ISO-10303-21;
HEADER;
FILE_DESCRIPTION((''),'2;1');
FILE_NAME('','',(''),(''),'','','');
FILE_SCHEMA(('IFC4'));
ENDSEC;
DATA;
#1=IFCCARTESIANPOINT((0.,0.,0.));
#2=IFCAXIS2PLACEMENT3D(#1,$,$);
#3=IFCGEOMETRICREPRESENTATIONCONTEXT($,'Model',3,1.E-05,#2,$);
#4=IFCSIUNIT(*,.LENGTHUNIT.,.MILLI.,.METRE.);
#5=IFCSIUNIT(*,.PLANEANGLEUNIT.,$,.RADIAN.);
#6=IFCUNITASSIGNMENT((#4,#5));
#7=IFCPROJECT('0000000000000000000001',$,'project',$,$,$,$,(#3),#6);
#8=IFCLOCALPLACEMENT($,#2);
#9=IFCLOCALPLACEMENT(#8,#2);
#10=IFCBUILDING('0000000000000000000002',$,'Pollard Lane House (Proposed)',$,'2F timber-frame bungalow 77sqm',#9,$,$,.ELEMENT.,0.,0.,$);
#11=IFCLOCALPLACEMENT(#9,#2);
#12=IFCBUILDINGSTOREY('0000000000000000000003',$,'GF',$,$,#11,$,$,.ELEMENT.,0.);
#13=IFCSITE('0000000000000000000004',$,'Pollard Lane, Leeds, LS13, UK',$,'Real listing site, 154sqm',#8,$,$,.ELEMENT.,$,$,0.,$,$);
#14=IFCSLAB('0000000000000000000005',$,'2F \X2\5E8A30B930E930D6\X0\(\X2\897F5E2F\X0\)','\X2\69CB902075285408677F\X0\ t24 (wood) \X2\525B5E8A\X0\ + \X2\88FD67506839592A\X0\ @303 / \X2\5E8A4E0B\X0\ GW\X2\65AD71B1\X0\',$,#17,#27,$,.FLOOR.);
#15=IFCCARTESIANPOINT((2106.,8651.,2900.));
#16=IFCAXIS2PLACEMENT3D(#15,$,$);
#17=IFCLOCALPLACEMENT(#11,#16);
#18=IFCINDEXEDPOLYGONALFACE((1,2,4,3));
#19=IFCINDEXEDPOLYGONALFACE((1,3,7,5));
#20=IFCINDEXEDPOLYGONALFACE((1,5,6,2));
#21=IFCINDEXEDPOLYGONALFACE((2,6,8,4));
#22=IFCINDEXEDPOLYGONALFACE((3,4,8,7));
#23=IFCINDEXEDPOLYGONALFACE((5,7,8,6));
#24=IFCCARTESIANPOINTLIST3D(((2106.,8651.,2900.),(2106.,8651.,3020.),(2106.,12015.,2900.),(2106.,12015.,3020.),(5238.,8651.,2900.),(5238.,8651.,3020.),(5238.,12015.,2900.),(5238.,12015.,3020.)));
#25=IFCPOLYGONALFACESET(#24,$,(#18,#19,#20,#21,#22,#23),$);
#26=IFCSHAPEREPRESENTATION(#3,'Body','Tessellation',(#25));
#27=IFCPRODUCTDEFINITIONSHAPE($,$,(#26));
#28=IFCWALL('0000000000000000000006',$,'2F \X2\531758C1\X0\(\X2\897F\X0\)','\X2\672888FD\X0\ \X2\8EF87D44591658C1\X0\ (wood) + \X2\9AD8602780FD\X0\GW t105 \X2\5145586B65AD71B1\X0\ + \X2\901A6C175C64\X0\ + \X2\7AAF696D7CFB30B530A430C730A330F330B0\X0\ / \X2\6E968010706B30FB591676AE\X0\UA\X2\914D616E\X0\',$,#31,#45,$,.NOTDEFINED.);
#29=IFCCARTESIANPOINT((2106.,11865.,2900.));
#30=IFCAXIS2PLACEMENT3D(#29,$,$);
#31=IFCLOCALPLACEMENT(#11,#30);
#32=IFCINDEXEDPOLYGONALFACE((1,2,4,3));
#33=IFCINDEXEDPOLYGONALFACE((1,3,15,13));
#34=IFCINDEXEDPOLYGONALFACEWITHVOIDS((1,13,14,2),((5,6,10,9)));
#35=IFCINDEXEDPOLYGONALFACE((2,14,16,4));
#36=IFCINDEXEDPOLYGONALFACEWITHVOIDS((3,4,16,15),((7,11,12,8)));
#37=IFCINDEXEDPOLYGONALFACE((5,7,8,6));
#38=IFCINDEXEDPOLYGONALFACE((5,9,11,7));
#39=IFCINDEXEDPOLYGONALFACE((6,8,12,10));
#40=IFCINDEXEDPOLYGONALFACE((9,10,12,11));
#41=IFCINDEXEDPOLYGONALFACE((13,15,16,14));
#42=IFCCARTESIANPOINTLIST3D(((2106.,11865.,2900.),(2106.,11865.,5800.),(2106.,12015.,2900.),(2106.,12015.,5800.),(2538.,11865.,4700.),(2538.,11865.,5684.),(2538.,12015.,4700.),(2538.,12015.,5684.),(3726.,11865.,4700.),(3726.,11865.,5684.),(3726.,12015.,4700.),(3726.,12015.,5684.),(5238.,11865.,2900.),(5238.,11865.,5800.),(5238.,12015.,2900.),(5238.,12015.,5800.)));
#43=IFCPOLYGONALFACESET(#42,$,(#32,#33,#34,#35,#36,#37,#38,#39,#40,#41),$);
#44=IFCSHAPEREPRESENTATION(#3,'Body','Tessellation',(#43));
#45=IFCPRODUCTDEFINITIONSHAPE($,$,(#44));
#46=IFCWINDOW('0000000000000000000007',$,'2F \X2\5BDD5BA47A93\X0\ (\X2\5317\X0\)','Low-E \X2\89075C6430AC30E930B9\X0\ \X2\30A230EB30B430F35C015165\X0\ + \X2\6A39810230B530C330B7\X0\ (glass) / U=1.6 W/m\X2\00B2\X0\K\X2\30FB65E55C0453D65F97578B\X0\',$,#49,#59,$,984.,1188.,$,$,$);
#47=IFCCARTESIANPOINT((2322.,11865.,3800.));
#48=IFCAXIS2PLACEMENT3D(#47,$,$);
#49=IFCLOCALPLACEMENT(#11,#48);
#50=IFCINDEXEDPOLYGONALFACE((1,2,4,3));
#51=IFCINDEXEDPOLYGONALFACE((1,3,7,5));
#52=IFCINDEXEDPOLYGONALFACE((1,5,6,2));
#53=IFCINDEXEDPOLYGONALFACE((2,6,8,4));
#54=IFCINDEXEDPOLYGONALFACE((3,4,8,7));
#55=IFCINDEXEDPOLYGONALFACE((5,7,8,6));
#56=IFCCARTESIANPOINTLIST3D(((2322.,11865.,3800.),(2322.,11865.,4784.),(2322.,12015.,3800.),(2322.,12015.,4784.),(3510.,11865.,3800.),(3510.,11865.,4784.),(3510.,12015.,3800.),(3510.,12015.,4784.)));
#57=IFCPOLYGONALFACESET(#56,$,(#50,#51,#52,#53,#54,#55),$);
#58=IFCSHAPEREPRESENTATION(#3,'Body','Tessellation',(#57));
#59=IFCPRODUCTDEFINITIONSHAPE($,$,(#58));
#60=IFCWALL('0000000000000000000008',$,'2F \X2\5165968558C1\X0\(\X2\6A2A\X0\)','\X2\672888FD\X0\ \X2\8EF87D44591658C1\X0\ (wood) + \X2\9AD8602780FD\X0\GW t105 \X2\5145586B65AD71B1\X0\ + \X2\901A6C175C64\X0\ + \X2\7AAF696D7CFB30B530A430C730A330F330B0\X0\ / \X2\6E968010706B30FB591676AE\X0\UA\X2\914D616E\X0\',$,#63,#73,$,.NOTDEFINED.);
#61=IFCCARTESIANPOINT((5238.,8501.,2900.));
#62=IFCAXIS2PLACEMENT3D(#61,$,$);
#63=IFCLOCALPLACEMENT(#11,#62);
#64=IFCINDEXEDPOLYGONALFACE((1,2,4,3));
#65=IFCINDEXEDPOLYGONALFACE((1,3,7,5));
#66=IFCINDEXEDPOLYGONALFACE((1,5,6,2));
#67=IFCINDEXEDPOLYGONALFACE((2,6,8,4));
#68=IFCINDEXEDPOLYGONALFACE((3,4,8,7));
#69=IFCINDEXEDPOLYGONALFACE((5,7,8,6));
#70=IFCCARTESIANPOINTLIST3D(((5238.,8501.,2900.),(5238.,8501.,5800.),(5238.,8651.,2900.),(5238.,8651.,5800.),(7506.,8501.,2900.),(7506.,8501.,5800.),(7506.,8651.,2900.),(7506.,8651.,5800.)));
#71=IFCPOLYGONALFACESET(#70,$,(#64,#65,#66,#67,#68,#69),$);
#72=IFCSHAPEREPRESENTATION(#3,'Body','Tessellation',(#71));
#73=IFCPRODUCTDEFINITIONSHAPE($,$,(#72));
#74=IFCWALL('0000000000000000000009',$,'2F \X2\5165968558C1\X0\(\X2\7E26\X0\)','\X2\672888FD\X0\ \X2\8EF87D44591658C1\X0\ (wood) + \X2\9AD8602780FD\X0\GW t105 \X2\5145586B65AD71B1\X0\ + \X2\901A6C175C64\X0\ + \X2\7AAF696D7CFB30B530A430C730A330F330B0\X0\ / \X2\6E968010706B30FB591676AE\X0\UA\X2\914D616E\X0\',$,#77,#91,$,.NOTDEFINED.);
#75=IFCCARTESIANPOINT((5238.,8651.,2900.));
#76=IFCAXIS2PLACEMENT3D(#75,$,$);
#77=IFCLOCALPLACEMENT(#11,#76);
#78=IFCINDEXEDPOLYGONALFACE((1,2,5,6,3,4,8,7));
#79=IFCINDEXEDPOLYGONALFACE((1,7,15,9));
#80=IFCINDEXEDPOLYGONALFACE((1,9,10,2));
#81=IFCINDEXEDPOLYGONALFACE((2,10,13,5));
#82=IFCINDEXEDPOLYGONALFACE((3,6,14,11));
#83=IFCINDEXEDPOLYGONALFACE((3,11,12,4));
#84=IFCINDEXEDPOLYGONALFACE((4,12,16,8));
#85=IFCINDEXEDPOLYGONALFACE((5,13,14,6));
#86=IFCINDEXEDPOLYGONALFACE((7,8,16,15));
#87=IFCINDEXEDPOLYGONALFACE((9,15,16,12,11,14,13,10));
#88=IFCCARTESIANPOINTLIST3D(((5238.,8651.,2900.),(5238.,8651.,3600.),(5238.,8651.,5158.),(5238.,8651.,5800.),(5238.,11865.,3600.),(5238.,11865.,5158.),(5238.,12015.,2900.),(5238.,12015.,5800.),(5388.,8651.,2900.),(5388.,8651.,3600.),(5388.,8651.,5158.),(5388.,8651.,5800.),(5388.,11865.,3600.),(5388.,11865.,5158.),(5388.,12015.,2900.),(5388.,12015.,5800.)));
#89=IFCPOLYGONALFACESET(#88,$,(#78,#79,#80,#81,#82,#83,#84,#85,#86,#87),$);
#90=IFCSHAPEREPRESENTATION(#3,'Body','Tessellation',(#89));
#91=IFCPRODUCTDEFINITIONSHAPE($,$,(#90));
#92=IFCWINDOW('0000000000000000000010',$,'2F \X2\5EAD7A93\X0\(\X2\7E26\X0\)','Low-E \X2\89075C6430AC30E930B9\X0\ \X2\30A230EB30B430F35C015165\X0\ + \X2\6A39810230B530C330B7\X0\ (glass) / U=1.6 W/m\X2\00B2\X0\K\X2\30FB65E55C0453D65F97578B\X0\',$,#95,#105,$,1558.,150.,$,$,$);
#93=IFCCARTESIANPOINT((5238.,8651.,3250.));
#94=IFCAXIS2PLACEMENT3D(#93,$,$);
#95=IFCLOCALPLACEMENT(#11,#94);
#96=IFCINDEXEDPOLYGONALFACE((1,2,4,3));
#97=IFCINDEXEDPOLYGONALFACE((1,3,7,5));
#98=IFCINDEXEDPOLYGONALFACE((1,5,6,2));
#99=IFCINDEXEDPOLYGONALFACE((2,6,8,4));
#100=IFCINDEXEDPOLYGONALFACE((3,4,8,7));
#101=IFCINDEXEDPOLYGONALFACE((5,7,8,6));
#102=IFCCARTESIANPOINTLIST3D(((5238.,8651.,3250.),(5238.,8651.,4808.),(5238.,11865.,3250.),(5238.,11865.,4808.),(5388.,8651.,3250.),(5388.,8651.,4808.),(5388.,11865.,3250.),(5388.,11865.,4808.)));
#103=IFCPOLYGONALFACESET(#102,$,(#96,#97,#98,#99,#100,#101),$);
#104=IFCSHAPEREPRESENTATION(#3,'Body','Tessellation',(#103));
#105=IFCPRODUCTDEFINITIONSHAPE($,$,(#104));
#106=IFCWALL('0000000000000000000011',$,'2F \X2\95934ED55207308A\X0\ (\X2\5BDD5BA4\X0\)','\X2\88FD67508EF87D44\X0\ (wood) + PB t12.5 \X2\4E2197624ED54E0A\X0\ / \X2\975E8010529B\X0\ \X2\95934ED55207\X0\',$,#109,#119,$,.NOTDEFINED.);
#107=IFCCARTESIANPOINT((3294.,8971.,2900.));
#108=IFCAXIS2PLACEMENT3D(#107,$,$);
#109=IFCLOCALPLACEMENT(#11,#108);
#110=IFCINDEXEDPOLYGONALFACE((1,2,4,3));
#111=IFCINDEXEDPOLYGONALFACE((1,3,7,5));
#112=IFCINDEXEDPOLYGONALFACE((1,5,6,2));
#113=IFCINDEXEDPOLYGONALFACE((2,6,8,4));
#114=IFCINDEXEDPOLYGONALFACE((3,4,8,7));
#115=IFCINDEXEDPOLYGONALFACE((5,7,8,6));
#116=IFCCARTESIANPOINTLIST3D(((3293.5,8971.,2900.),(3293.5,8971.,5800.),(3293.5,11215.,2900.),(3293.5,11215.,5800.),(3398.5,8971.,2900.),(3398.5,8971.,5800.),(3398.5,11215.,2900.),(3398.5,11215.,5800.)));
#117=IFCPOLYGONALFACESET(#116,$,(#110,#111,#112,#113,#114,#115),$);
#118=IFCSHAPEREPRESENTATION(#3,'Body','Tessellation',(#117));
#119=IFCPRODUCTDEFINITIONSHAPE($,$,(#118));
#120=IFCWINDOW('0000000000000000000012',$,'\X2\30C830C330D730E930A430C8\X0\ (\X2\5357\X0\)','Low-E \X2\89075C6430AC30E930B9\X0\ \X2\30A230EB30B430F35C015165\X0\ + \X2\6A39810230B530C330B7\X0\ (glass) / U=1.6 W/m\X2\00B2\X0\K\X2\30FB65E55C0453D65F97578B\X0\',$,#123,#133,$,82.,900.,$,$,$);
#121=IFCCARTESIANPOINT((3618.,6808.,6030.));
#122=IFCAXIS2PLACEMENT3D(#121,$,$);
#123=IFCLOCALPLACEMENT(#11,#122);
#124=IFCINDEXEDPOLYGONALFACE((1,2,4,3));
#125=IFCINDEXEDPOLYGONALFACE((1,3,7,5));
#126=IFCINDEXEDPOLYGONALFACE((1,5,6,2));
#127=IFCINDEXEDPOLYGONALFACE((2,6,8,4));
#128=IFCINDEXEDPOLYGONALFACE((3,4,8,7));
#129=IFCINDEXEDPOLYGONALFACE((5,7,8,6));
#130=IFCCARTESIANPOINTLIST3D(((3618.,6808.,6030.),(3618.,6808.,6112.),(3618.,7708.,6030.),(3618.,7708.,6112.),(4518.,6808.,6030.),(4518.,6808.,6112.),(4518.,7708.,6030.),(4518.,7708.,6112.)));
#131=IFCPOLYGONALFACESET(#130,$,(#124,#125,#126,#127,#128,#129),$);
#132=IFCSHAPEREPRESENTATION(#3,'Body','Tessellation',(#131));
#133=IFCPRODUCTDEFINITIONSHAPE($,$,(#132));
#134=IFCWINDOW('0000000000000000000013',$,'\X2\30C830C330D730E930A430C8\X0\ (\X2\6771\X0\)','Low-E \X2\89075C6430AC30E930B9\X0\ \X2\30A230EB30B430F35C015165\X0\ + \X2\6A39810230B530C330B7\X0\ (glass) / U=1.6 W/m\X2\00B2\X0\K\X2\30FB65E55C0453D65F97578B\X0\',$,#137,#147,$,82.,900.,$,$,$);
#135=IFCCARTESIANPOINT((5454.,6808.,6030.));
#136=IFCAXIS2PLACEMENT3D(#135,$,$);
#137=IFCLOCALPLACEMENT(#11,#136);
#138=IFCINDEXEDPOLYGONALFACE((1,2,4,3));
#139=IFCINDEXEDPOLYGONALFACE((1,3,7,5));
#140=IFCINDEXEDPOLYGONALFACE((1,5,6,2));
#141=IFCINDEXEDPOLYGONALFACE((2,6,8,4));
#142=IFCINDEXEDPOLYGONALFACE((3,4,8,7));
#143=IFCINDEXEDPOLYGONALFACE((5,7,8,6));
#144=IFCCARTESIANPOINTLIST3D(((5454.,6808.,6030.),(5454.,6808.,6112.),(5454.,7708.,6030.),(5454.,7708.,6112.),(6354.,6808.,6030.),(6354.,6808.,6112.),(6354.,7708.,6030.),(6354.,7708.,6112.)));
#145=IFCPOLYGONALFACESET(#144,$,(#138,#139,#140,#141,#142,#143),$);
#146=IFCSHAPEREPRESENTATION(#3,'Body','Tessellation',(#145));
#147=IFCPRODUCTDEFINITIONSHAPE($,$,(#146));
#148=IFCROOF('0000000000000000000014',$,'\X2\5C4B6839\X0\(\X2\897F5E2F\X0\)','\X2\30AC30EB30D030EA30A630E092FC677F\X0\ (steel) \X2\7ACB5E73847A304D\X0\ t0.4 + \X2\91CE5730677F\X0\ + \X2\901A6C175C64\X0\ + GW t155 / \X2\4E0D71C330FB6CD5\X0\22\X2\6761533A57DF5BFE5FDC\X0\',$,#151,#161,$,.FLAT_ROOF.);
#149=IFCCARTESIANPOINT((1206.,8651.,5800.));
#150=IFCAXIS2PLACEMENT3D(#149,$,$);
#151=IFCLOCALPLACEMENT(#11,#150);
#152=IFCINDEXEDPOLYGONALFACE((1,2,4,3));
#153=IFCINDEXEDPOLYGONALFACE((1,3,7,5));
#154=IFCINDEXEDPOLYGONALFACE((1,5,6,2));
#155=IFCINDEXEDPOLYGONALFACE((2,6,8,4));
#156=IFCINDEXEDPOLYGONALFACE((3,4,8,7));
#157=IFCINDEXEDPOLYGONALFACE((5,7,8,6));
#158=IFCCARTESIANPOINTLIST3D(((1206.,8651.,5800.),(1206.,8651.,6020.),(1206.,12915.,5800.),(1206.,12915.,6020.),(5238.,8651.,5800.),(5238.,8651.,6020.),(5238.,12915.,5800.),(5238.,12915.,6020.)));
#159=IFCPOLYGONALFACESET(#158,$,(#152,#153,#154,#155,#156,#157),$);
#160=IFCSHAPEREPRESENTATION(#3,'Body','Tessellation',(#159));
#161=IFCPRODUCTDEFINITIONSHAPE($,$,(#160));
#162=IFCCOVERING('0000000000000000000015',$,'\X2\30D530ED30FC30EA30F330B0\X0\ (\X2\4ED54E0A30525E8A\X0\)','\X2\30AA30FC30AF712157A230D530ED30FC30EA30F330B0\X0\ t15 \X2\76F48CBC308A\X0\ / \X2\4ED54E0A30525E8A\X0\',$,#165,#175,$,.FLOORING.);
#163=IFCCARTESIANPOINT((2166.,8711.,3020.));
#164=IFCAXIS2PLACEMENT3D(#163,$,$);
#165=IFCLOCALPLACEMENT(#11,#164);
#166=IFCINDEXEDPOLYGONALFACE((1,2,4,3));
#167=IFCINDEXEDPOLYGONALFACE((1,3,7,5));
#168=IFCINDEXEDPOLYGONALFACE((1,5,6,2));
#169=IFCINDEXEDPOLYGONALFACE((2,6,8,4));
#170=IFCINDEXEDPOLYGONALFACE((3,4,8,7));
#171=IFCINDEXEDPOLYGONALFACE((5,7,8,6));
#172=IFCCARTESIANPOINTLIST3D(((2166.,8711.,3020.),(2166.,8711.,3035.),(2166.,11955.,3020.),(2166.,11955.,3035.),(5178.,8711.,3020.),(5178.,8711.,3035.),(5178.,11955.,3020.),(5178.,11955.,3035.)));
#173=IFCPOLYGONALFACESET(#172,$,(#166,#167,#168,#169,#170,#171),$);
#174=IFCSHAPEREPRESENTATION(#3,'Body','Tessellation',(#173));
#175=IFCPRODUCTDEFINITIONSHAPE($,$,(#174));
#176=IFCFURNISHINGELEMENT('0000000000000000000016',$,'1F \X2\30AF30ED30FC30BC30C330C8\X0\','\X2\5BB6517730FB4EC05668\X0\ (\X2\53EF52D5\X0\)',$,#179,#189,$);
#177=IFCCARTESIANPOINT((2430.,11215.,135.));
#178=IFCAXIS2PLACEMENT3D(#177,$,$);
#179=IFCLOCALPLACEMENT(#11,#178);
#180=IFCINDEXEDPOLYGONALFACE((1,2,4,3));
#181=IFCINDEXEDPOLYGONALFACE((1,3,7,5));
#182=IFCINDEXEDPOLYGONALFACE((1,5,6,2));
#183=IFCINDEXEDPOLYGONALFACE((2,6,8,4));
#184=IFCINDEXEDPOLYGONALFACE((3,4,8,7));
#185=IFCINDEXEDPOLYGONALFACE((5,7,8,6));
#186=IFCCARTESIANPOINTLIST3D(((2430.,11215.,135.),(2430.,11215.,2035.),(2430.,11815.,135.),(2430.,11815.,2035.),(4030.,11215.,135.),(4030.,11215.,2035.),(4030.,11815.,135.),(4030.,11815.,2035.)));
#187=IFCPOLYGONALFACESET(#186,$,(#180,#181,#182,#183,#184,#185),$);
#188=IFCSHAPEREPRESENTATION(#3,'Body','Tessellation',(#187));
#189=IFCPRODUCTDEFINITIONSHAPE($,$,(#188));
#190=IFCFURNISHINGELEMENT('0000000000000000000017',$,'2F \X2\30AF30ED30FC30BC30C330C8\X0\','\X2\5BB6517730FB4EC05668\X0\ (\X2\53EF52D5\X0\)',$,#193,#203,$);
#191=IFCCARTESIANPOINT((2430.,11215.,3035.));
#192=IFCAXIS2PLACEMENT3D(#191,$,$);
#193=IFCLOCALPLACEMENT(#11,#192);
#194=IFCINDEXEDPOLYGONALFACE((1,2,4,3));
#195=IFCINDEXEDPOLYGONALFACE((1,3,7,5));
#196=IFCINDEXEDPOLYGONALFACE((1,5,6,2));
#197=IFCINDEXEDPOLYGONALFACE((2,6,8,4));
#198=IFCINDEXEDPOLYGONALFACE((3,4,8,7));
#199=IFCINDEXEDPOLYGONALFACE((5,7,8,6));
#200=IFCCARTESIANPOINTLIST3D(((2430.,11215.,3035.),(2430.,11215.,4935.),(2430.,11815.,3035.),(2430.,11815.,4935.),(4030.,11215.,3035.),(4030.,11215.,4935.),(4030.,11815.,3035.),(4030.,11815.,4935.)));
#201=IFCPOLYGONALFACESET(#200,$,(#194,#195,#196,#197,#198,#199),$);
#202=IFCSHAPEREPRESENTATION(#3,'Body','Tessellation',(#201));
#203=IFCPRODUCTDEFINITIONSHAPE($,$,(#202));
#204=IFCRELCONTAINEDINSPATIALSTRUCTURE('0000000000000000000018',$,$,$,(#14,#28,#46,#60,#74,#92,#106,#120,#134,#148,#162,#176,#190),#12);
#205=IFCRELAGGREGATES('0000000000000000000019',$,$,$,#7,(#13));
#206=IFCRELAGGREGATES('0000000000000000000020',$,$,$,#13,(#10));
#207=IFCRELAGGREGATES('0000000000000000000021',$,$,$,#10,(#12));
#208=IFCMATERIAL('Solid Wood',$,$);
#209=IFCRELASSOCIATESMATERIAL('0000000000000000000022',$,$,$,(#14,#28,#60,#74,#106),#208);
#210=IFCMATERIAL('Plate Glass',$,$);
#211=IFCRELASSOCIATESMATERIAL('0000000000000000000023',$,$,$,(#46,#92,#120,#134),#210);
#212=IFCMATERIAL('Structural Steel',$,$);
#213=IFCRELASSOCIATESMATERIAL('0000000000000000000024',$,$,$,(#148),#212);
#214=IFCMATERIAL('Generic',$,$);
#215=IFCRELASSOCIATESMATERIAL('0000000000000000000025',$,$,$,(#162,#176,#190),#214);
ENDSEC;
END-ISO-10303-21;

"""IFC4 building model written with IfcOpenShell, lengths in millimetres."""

from ifc_helpers import new_model, si_unit, frame, frame_2d, origin, place, context, project, spatial, rectangle, extrude, material, element, fill, save


model = new_model("IFC4")

# Units and contexts
model_context = context("Model", 3, precision=1e-05, world=origin())
ifc_project = project(units=[si_unit("LENGTHUNIT", "METRE", prefix="MILLI"), si_unit("PLANEANGLEUNIT", "RADIAN")], contexts=[model_context])

# Site, building, storey
site_placement = place(None, origin())
site = spatial("IfcSite", under=ifc_project, at=site_placement, Name="Pollard Lane, Leeds, LS13, UK", ObjectType="Real listing site, 154sqm", CompositionType="ELEMENT", RefElevation=0.0)
building_placement = place(site_placement, origin())
building = spatial("IfcBuilding", under=site, at=building_placement, Name="Pollard Lane House (Proposed)", ObjectType="2F timber-frame bungalow 77sqm", CompositionType="ELEMENT", ElevationOfRefHeight=0.0, ElevationOfTerrain=0.0)
storey_placement = place(building_placement, origin())
storey = spatial("IfcBuildingStorey", under=building, at=storey_placement, Name="GF", CompositionType="ELEMENT", Elevation=0.0)

# Slab
ifc_material_1 = material(Name="Solid Wood")
slab_placement = place(storey_placement, frame((2106.0, 8651.0, 2900.0)))
element("IfcSlab", 1, at=slab_placement, inside=storey, material=ifc_material_1, Name="2F 床スラブ(西帯)", Description="構造用合板 t24 (wood) 剛床 + 製材根太 @303 / 床下 GW断熱", PredefinedType="FLOOR", context=model_context, shape_type="SweptSolid", body=[
    extrude(rectangle(XDim=3132.0, YDim=3364.0, at=frame_2d((1566.0, 1682.0))), frame((2106.0, 8651.0, 2900.0)), (0.0, 0.0, 1.0), 120.0),
])

# Wall, opening, window
wall_1_placement = place(storey_placement, frame((2106.0, 11865.0, 2900.0)))
wall_1 = element("IfcWall", 2, at=wall_1_placement, inside=storey, material=ifc_material_1, Name="2F 北壁(西)", Description="木製 軸組外壁 (wood) + 高性能GW t105 充填断熱 + 通気層 + 窯業系サイディング / 準耐火・外皮UA配慮", PredefinedType="NOTDEFINED", context=model_context, shape_type="SweptSolid", body=[
    extrude(rectangle(XDim=3132.0, YDim=150.0, at=frame_2d((1566.0, 75.0))), frame((2106.0, 11865.0, 2900.0)), (0.0, 0.0, 1.0), 2900.0),
])
opening_1_placement = place(storey_placement, frame((2322.0, 11865.0, 3800.0)))
opening_1 = element("IfcOpeningElement", 3, at=opening_1_placement, cuts=wall_1, PredefinedType="NOTDEFINED", context=model_context, shape_type="SweptSolid", body=[
    extrude(rectangle(XDim=1188.0, YDim=150.0, at=frame_2d((594.0, 75.0))), frame((2322.0, 11865.0, 3800.0)), (0.0, 0.0, 1.0), 984.0),
])
ifc_material_2 = material(Name="Plate Glass")
window_1_placement = place(storey_placement, frame((2322.0, 11865.0, 3800.0)))
window_1 = element("IfcWindow", 4, at=window_1_placement, inside=storey, material=ifc_material_2, Name="2F 寝室窓 (北)", Description="Low-E 複層ガラス アルゴン封入 + 樹脂サッシ (glass) / U=1.6 W/m²K・日射取得型", OverallHeight=984.0, OverallWidth=1188.0, context=model_context, shape_type="SweptSolid", body=[
    extrude(rectangle(XDim=1188.0, YDim=150.0, at=frame_2d((594.0, 75.0))), frame((2322.0, 11865.0, 3800.0)), (0.0, 0.0, 1.0), 984.0),
])
fill(opening_1, window_1)

# Wall
wall_2_placement = place(storey_placement, frame((5238.0, 8501.0, 2900.0)))
element("IfcWall", 5, at=wall_2_placement, inside=storey, material=ifc_material_1, Name="2F 入隅壁(横)", Description="木製 軸組外壁 (wood) + 高性能GW t105 充填断熱 + 通気層 + 窯業系サイディング / 準耐火・外皮UA配慮", PredefinedType="NOTDEFINED", context=model_context, shape_type="SweptSolid", body=[
    extrude(rectangle(XDim=2268.0, YDim=150.0, at=frame_2d((1134.0, 75.0))), frame((5238.0, 8501.0, 2900.0)), (0.0, 0.0, 1.0), 2900.0),
])

# Wall, opening, window
wall_3_placement = place(storey_placement, frame((5238.0, 8651.0, 2900.0)))
wall_3 = element("IfcWall", 6, at=wall_3_placement, inside=storey, material=ifc_material_1, Name="2F 入隅壁(縦)", Description="木製 軸組外壁 (wood) + 高性能GW t105 充填断熱 + 通気層 + 窯業系サイディング / 準耐火・外皮UA配慮", PredefinedType="NOTDEFINED", context=model_context, shape_type="SweptSolid", body=[
    extrude(rectangle(XDim=150.0, YDim=3364.0, at=frame_2d((75.0, 1682.0))), frame((5238.0, 8651.0, 2900.0)), (0.0, 0.0, 1.0), 2900.0),
])
opening_2_placement = place(storey_placement, frame((5238.0, 8651.0, 3250.0)))
opening_2 = element("IfcOpeningElement", 7, at=opening_2_placement, cuts=wall_3, PredefinedType="NOTDEFINED", context=model_context, shape_type="SweptSolid", body=[
    extrude(rectangle(XDim=150.0, YDim=3214.0, at=frame_2d((75.0, 1607.0))), frame((5238.0, 8651.0, 3250.0)), (0.0, 0.0, 1.0), 1558.0),
])
window_2_placement = place(storey_placement, frame((5238.0, 8651.0, 3250.0)))
window_2 = element("IfcWindow", 8, at=window_2_placement, inside=storey, material=ifc_material_2, Name="2F 庭窓(縦)", Description="Low-E 複層ガラス アルゴン封入 + 樹脂サッシ (glass) / U=1.6 W/m²K・日射取得型", OverallHeight=1558.0, OverallWidth=150.0, context=model_context, shape_type="SweptSolid", body=[
    extrude(rectangle(XDim=150.0, YDim=3214.0, at=frame_2d((75.0, 1607.0))), frame((5238.0, 8651.0, 3250.0)), (0.0, 0.0, 1.0), 1558.0),
])
fill(opening_2, window_2)

# Wall
wall_4_placement = place(storey_placement, frame((3294.0, 8971.0, 2900.0)))
element("IfcWall", 9, at=wall_4_placement, inside=storey, material=ifc_material_1, Name="2F 間仕切り (寝室)", Description="製材軸組 (wood) + PB t12.5 両面仕上 / 非耐力 間仕切", PredefinedType="NOTDEFINED", context=model_context, shape_type="SweptSolid", body=[
    extrude(rectangle(XDim=105.0, YDim=2244.0, at=frame_2d((52.0, 1122.0))), frame((3294.0, 8971.0, 2900.0)), (0.0, 0.0, 1.0), 2900.0),
])

# Windows
window_3_placement = place(storey_placement, frame((3618.0, 6808.0, 6030.0)))
element("IfcWindow", 10, at=window_3_placement, inside=storey, material=ifc_material_2, Name="トップライト (南)", Description="Low-E 複層ガラス アルゴン封入 + 樹脂サッシ (glass) / U=1.6 W/m²K・日射取得型", OverallHeight=82.0, OverallWidth=900.0, context=model_context, shape_type="SweptSolid", body=[
    extrude(rectangle(XDim=900.0, YDim=900.0, at=frame_2d((450.0, 450.0))), frame((3618.0, 6808.0, 6030.0)), (0.0, 0.0, 1.0), 82.0),
])
window_4_placement = place(storey_placement, frame((5454.0, 6808.0, 6030.0)))
element("IfcWindow", 11, at=window_4_placement, inside=storey, material=ifc_material_2, Name="トップライト (東)", Description="Low-E 複層ガラス アルゴン封入 + 樹脂サッシ (glass) / U=1.6 W/m²K・日射取得型", OverallHeight=82.0, OverallWidth=900.0, context=model_context, shape_type="SweptSolid", body=[
    extrude(rectangle(XDim=900.0, YDim=900.0, at=frame_2d((450.0, 450.0))), frame((5454.0, 6808.0, 6030.0)), (0.0, 0.0, 1.0), 82.0),
])

# Roof
ifc_material_3 = material(Name="Structural Steel")
for number, where, name in (
    (12, (1206.0, 8651.0, 5800.0), "屋根(西帯)"),
):
    element("IfcRoof", number, at=place(storey_placement, frame(where)), inside=storey, material=ifc_material_3, Name=name, Description="ガルバリウム鋼板 (steel) 立平葺き t0.4 + 野地板 + 通気層 + GW t155 / 不燃・法22条区域対応", PredefinedType="FLAT_ROOF", context=model_context, shape_type="SweptSolid", body=[
        extrude(rectangle(XDim=4032.0, YDim=4264.0, at=frame_2d((2016.0, 2132.0))), frame((1206.0, 8651.0, 5800.0)), (0.0, 0.0, 1.0), 220.0),
    ])

# Covering
ifc_material_4 = material(Name="Generic")
covering_placement = place(storey_placement, frame((2166.0, 8711.0, 3020.0)))
element("IfcCovering", 13, at=covering_placement, inside=storey, material=ifc_material_4, Name="フローリング (仕上げ床)", Description="オーク無垢フローリング t15 直貼り / 仕上げ床", PredefinedType="FLOORING", context=model_context, shape_type="SweptSolid", body=[
    extrude(rectangle(XDim=3012.0, YDim=3244.0, at=frame_2d((1506.0, 1622.0))), frame((2166.0, 8711.0, 3020.0)), (0.0, 0.0, 1.0), 15.0),
])

# Furnishing elements
furnishing_1_placement = place(storey_placement, frame((2430.0, 11215.0, 135.0)))
element("IfcFurnishingElement", 14, at=furnishing_1_placement, inside=storey, material=ifc_material_4, Name="1F クローゼット", Description="家具・什器 (可動)", context=model_context, shape_type="SweptSolid", body=[
    extrude(rectangle(XDim=1600.0, YDim=600.0, at=frame_2d((800.0, 300.0))), frame((2430.0, 11215.0, 135.0)), (0.0, 0.0, 1.0), 1900.0),
])
furnishing_2_placement = place(storey_placement, frame((2430.0, 11215.0, 3035.0)))
element("IfcFurnishingElement", 15, at=furnishing_2_placement, inside=storey, material=ifc_material_4, Name="2F クローゼット", Description="家具・什器 (可動)", context=model_context, shape_type="SweptSolid", body=[
    extrude(rectangle(XDim=1600.0, YDim=600.0, at=frame_2d((800.0, 300.0))), frame((2430.0, 11215.0, 3035.0)), (0.0, 0.0, 1.0), 1900.0),
])

save(model, "model.ifc")
